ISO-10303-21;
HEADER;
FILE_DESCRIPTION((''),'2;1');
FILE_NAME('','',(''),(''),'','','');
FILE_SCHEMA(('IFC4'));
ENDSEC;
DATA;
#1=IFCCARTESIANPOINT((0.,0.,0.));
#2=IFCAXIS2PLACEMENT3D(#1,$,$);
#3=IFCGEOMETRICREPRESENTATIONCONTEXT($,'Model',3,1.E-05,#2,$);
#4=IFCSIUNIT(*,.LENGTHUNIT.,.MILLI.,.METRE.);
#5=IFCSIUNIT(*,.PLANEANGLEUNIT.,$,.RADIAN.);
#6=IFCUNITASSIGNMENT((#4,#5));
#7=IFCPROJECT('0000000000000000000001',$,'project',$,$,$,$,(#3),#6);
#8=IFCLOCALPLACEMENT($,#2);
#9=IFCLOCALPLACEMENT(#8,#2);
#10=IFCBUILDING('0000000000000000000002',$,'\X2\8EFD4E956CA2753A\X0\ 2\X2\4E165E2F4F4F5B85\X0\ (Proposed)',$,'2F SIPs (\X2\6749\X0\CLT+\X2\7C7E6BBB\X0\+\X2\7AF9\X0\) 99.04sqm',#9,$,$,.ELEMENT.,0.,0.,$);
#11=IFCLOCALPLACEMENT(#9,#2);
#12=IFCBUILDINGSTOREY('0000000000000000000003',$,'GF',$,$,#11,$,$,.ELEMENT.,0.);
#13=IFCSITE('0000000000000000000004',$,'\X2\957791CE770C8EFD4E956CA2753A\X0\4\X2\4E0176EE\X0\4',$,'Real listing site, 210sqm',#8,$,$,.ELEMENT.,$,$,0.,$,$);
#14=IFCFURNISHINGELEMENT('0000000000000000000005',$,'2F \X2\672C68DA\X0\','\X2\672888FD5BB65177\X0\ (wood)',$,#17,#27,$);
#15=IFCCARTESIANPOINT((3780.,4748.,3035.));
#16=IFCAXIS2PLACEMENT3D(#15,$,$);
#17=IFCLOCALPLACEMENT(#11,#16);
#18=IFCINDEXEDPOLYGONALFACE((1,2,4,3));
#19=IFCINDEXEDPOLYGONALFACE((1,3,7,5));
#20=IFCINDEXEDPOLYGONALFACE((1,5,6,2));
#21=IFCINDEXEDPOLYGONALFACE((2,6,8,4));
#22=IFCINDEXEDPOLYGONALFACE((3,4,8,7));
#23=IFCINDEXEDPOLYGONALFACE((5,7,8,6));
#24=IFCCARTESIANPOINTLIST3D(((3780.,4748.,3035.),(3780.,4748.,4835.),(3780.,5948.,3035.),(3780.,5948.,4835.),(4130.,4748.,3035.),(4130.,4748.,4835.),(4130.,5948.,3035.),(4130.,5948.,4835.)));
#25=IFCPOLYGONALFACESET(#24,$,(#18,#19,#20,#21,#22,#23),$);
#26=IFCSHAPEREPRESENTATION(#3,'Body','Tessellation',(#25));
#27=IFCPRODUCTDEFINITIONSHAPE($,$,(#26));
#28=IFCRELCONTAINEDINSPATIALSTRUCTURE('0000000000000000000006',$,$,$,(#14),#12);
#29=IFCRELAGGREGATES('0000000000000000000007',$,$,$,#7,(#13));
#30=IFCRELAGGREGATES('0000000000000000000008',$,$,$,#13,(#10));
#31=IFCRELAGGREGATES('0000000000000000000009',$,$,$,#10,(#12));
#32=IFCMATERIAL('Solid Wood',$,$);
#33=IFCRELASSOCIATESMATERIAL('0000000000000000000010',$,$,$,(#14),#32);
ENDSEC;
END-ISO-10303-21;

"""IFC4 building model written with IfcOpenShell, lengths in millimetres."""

from ifc_helpers import new_model, si_unit, frame, frame_2d, origin, place, context, project, spatial, rectangle, extrude, material, element, save


model = new_model("IFC4")

# Units and contexts
model_context = context("Model", 3, precision=1e-05, world=origin())
ifc_project = project(units=[si_unit("LENGTHUNIT", "METRE", prefix="MILLI"), si_unit("PLANEANGLEUNIT", "RADIAN")], contexts=[model_context])

# Site, building, storey
site_placement = place(None, origin())
site = spatial("IfcSite", under=ifc_project, at=site_placement, Name="長野県軽井沢町4丁目4", ObjectType="Real listing site, 210sqm", CompositionType="ELEMENT", RefElevation=0.0)
building_placement = place(site_placement, origin())
building = spatial("IfcBuilding", under=site, at=building_placement, Name="軽井沢町 2世帯住宅 (Proposed)", ObjectType="2F SIPs (杉CLT+籾殻+竹) 99.04sqm", CompositionType="ELEMENT", ElevationOfRefHeight=0.0, ElevationOfTerrain=0.0)
storey_placement = place(building_placement, origin())
storey = spatial("IfcBuildingStorey", under=building, at=storey_placement, Name="GF", CompositionType="ELEMENT", Elevation=0.0)

# Shared definitions
ifc_material_1 = material(Name="Solid Wood")

# Furnishing element
furnishing_placement = place(storey_placement, frame((3780.0, 4748.0, 3035.0)))
element("IfcFurnishingElement", 1, at=furnishing_placement, inside=storey, material=ifc_material_1, Name="2F 本棚", Description="木製家具 (wood)", context=model_context, shape_type="SweptSolid", body=[
    extrude(rectangle(XDim=350.0, YDim=1200.0, at=frame_2d((175.0, 600.0))), frame((3780.0, 4748.0, 3035.0)), (0.0, 0.0, 1.0), 1800.0),
])

save(model, "model.ifc")
